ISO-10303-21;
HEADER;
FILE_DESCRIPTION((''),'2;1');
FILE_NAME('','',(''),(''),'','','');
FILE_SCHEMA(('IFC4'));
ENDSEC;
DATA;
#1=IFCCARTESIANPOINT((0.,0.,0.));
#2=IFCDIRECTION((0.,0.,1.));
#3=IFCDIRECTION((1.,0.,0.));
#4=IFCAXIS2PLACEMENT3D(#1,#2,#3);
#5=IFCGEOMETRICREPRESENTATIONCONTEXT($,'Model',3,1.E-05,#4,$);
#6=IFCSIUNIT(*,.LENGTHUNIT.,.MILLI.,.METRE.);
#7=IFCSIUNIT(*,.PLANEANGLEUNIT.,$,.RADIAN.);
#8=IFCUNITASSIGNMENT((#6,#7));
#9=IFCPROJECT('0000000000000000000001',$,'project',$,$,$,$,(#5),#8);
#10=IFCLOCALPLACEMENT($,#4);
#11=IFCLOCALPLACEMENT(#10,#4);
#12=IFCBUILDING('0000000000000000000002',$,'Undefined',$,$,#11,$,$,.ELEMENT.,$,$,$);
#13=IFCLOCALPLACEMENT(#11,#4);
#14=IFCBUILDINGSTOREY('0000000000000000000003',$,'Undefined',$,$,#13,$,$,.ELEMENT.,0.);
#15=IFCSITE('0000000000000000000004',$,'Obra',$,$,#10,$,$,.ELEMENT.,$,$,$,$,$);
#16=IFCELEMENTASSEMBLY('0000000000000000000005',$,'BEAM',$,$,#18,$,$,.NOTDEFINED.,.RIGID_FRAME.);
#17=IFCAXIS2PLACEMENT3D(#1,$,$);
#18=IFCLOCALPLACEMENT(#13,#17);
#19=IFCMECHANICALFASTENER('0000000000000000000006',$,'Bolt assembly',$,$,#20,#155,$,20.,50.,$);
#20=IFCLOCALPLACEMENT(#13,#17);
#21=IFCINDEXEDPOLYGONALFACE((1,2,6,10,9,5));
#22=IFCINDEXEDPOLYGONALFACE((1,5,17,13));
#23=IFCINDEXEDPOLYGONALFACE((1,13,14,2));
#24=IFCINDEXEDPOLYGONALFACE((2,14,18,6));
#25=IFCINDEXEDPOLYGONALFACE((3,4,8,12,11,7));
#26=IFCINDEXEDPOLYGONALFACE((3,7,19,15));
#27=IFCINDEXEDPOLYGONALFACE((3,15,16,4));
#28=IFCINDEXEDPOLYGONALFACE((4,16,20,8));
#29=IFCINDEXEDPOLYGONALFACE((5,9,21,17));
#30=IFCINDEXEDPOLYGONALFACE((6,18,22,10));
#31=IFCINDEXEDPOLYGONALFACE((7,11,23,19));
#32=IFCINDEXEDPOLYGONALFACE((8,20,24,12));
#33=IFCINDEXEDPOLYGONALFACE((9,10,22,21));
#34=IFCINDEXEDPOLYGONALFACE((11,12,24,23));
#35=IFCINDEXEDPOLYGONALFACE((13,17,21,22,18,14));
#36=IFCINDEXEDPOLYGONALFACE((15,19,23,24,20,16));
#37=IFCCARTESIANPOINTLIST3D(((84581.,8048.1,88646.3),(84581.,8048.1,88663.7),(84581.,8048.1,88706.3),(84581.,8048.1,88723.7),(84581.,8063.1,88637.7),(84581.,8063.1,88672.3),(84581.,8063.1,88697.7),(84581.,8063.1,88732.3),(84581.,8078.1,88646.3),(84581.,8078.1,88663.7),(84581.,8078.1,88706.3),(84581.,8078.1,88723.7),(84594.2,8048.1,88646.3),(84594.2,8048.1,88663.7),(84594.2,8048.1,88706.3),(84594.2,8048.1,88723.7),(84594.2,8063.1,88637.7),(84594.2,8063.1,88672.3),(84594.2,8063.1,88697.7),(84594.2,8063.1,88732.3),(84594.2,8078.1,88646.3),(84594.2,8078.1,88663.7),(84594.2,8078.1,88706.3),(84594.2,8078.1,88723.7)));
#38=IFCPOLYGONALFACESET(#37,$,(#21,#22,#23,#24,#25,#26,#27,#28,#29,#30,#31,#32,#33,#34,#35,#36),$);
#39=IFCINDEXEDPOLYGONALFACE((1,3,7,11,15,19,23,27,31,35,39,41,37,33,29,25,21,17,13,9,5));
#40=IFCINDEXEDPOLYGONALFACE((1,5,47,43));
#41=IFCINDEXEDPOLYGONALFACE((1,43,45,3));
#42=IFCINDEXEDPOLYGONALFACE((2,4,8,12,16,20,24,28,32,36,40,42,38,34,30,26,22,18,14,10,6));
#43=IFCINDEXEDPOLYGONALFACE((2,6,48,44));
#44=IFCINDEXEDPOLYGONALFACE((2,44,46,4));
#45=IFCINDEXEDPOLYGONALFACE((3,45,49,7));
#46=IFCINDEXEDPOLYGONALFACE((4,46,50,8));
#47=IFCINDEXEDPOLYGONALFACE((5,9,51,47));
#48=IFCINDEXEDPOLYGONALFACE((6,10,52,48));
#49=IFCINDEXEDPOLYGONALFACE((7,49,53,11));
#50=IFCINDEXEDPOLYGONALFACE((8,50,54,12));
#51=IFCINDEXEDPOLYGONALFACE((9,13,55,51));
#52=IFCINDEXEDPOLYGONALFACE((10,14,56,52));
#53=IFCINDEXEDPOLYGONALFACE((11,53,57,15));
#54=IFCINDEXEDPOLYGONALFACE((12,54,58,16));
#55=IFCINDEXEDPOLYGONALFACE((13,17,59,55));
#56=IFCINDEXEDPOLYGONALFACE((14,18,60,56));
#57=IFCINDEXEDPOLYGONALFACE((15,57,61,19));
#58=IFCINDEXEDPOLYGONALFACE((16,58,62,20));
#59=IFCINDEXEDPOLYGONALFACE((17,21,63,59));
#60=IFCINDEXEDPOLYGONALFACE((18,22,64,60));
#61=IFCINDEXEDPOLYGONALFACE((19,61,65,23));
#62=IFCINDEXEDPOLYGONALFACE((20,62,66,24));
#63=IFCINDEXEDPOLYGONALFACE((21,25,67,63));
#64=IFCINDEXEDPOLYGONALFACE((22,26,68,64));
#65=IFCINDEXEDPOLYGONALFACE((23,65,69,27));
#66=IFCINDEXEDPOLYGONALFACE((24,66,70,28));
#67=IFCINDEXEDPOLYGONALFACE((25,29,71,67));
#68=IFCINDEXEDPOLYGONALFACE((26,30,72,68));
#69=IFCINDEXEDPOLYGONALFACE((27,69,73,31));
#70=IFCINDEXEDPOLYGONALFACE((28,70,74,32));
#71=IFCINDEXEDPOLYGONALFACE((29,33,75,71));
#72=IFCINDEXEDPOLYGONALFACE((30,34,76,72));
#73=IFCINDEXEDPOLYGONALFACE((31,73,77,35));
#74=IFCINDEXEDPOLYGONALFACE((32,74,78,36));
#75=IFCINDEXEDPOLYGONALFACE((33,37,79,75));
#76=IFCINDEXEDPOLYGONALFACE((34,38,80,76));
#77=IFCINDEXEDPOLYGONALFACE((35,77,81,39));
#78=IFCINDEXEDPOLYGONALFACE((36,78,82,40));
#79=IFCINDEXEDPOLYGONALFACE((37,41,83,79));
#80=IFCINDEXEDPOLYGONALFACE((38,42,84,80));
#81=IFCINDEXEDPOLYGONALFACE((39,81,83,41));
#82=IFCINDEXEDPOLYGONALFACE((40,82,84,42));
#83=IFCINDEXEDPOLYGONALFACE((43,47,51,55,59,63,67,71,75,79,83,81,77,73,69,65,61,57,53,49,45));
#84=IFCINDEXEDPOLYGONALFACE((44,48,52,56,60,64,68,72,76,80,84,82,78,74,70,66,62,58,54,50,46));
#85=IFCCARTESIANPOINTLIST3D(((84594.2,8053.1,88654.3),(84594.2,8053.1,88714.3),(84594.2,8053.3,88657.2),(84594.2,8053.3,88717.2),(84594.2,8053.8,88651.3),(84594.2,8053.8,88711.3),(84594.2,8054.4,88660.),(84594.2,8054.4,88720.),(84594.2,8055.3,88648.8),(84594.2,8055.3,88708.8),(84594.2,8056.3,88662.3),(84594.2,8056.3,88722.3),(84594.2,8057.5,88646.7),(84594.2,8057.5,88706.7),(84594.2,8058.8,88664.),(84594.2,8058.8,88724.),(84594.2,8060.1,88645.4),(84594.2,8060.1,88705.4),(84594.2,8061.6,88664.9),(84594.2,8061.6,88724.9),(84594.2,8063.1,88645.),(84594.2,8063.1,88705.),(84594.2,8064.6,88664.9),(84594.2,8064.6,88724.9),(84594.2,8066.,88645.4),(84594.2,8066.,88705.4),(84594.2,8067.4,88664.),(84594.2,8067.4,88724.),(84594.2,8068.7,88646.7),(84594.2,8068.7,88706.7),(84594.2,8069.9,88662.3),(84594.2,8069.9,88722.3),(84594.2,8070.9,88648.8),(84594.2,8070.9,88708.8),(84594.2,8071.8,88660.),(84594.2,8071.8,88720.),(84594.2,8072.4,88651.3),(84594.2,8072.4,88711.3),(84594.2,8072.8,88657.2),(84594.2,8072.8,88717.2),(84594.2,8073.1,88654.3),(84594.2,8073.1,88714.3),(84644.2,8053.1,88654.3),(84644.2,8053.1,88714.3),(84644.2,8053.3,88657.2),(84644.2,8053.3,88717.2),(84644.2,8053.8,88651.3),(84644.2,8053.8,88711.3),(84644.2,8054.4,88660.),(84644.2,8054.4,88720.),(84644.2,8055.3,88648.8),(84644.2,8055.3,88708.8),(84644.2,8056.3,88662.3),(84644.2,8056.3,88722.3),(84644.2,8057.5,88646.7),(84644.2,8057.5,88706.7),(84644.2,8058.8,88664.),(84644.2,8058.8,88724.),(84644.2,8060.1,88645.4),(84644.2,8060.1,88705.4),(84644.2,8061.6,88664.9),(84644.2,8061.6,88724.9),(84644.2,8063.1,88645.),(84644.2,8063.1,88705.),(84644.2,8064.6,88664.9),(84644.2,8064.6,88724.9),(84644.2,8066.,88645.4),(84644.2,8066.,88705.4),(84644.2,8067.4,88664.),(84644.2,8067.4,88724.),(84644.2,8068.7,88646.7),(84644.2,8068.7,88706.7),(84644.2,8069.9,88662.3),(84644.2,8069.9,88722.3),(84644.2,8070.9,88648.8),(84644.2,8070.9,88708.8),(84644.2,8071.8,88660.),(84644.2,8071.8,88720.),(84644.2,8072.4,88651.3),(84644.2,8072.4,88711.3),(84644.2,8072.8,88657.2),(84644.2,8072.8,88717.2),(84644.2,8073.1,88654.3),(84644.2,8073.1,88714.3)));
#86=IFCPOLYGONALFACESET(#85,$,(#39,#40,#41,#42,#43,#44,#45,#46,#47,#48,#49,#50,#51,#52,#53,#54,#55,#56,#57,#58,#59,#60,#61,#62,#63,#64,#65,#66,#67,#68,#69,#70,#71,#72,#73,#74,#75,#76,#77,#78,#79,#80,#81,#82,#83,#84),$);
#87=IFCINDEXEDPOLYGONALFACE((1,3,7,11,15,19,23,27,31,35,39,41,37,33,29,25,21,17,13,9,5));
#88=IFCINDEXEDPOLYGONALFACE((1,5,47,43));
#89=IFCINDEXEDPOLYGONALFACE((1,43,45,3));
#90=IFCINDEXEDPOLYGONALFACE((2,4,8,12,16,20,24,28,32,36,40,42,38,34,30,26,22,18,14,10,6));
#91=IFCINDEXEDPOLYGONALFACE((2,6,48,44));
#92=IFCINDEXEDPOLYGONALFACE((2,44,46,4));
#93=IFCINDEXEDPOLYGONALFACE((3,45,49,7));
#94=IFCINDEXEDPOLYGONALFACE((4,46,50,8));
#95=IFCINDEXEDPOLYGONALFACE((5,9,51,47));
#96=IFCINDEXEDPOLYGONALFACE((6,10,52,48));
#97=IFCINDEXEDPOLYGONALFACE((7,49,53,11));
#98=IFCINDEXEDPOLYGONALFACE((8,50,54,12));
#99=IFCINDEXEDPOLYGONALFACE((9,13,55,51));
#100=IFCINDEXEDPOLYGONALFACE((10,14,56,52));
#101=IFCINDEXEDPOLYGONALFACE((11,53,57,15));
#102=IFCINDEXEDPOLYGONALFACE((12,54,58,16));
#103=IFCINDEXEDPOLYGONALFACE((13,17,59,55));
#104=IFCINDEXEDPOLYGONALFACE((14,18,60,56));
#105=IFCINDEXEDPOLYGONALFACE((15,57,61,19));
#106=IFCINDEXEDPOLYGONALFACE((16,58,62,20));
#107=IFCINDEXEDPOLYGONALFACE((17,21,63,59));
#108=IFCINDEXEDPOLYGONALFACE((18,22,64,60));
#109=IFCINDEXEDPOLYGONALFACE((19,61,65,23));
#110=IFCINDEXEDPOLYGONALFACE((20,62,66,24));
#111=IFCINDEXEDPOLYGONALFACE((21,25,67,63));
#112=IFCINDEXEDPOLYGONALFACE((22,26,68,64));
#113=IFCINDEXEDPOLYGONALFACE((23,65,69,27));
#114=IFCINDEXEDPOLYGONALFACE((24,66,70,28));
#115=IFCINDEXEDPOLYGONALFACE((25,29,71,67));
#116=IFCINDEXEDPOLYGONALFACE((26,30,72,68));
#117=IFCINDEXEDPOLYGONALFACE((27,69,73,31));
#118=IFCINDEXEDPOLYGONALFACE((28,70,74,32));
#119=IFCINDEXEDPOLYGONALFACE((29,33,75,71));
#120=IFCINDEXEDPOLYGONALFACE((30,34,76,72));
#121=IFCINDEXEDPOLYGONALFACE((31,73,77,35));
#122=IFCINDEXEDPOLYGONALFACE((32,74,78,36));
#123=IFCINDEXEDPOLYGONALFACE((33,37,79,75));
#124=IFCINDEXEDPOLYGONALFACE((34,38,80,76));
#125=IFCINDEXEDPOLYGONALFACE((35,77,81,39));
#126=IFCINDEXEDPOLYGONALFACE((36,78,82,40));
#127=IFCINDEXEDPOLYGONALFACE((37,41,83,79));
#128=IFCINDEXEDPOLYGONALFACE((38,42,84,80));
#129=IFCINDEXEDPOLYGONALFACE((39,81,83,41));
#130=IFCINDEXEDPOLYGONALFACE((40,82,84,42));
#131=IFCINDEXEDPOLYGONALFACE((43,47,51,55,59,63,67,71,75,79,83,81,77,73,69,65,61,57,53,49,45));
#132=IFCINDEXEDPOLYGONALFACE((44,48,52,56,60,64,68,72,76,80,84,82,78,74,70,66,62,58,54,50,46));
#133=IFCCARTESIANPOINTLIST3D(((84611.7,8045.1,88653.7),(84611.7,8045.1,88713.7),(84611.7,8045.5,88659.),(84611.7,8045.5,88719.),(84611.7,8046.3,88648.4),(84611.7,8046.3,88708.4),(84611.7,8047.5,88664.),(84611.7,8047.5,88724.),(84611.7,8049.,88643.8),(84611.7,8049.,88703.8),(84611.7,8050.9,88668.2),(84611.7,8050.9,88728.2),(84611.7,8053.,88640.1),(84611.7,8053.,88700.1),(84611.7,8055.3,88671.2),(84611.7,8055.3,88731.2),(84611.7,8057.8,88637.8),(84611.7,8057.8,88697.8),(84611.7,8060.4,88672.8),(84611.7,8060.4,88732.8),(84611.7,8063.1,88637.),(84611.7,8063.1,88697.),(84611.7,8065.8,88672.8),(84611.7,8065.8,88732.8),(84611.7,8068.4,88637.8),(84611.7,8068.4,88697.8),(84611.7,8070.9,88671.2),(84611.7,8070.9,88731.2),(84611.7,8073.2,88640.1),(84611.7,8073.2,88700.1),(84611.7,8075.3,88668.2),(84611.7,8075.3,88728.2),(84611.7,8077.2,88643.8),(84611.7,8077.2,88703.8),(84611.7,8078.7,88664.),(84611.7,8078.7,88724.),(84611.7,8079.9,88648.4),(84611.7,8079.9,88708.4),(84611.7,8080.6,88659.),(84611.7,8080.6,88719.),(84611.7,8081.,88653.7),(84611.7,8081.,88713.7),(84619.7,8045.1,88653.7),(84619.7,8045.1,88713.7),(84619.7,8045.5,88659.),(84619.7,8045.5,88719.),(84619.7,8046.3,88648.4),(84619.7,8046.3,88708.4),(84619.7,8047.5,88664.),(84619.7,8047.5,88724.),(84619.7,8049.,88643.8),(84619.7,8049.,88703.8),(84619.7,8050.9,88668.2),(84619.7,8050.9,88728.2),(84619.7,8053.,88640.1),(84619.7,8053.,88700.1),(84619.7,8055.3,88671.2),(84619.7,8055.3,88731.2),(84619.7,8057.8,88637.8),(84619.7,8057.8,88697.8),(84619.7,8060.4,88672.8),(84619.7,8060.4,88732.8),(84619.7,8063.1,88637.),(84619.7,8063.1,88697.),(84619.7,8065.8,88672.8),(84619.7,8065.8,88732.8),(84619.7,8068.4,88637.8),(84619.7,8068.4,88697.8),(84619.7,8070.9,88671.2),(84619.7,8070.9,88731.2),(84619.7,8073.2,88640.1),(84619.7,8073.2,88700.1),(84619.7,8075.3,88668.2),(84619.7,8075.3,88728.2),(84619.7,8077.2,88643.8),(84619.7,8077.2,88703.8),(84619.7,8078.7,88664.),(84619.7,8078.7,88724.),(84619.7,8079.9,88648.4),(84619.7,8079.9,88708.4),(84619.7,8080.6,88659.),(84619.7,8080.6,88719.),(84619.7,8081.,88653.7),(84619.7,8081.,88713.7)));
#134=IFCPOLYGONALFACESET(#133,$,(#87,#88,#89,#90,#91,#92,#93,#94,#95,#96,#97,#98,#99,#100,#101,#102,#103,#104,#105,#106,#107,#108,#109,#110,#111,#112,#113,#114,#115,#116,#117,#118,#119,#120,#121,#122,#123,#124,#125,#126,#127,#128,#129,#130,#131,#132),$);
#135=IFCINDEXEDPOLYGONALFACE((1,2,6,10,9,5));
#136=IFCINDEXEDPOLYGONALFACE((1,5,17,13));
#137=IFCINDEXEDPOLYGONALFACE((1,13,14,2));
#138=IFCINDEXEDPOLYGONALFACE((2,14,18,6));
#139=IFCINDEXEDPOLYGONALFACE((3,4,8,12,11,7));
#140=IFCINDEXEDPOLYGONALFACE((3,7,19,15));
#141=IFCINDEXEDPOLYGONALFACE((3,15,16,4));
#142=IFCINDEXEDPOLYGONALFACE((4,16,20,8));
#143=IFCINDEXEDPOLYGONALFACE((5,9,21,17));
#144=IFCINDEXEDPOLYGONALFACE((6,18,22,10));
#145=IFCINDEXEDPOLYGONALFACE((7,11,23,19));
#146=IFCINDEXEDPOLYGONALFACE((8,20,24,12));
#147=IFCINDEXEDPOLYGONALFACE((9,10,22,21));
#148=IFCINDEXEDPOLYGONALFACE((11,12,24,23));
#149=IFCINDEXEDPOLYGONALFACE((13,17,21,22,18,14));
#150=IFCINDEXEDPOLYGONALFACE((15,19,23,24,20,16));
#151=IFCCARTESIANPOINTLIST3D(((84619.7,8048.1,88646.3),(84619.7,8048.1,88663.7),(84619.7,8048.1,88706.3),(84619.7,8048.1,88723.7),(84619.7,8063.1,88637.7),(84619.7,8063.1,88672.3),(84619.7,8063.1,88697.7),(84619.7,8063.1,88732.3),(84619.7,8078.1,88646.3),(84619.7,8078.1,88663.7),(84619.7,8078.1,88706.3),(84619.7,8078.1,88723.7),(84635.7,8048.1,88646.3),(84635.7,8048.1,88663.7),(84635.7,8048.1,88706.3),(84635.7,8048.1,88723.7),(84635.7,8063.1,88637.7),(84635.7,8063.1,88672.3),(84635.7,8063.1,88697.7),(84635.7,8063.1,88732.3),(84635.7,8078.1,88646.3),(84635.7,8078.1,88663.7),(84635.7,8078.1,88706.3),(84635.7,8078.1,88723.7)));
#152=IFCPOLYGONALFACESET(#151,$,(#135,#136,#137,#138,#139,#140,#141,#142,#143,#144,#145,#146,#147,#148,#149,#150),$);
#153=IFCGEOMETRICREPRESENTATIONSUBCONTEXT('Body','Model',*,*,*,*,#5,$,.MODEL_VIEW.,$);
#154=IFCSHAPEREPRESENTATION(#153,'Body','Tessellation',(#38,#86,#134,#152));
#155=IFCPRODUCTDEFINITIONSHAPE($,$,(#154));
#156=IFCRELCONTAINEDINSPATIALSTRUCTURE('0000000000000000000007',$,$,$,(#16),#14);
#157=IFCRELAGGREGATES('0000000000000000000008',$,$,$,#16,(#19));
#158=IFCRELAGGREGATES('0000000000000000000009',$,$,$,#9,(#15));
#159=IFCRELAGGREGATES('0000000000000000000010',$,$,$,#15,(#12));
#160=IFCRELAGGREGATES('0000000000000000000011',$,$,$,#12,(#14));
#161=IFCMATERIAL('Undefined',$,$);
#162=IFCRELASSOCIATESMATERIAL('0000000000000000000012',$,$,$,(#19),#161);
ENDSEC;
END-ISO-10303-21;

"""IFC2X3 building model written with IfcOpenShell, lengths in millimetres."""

from ifc_helpers import new_model, si_unit, frame, origin_with_axes, origin_2d_with_axis, place, context, subcontext, project, spatial, polyline, circle, outline, extrude, source, transform, mapped, material, element, aggregate, save


model = new_model("IFC2X3")

# Units and contexts
model_context = context("Model", 3, precision=1e-05, world=origin_with_axes())
body_context = subcontext(model_context, "Body", "Model", "MODEL_VIEW")
ifc_project = project(units=[si_unit("LENGTHUNIT", "METRE", prefix="MILLI"), si_unit("PLANEANGLEUNIT", "RADIAN")], contexts=[model_context])

# Site, building, storey
site_placement = place(None, origin_with_axes())
site = spatial("IfcSite", under=ifc_project, at=site_placement, Name="Obra", CompositionType="ELEMENT")
building_placement = place(site_placement, origin_with_axes())
building = spatial("IfcBuilding", under=site, at=building_placement, Name="Undefined", CompositionType="ELEMENT")
storey_placement = place(building_placement, origin_with_axes())
storey = spatial("IfcBuildingStorey", under=building, at=storey_placement, Name="Undefined", CompositionType="ELEMENT", Elevation=0.0)

# Shared definitions
ifc_material_1 = material(Name="Undefined")

# Element assembly, mechanical fastener
shared_shape_1 = source(origin_with_axes(), body_context, "Body", "SweptSolid", [
    extrude(outline(polyline([(17.3, 0.0), (8.7, 15.0), (-8.7, 15.0), (-17.3, 0.0), (-8.7, -15.0), (8.7, -15.0), (17.3, 0.0)])), frame((0.0, -27.0, 0.0), z_axis=(0.0, 1.0, 0.0), x_axis=(1.0, 0.0, 0.0)), (0.0, 0.0, 1.0), 13.2),
    extrude(circle(Radius=10.0, at=origin_2d_with_axis()), frame((0.0, -13.8, 0.0), z_axis=(0.0, 1.0, 0.0), x_axis=(1.0, 0.0, 0.0)), (0.0, 0.0, 1.0), 50.0),
    extrude(circle(Radius=18.0, at=origin_2d_with_axis()), frame((0.0, 3.7, 0.0), z_axis=(0.0, 1.0, 0.0), x_axis=(1.0, 0.0, 0.0)), (0.0, 0.0, 1.0), 8.0),
    extrude(outline(polyline([(17.3, 0.0), (8.7, 15.0), (-8.7, 15.0), (-17.3, 0.0), (-8.7, -15.0), (8.7, -15.0), (17.3, 0.0)])), frame((0.0, 11.7, 0.0), z_axis=(0.0, 1.0, 0.0), x_axis=(1.0, 0.0, 0.0)), (0.0, 0.0, 1.0), 16.0),
])
assembly_1_placement = place(storey_placement, origin_with_axes())
assembly_1 = element("IfcElementAssembly", 1, at=assembly_1_placement, inside=storey, Name="BEAM", AssemblyPlace="NOTDEFINED", PredefinedType="RIGID_FRAME")
mechanical_fastener_1_placement = place(assembly_1_placement, frame((84607.9, 8103.1, 88850.0), z_axis=(0.0, -1.0, 0.0), x_axis=(0.0, 0.0, -1.0)))
mechanical_fastener_1 = element("IfcMechanicalFastener", 2, at=mechanical_fastener_1_placement, material=ifc_material_1, Name="Bolt assembly", NominalDiameter=20.0, NominalLength=50.0, context=body_context, shape_type="MappedRepresentation", body=[
    mapped(shared_shape_1, transform((135.0, 0.0, 40.0))),
    mapped(shared_shape_1, transform((195.0, 0.0, 40.0))),
])
aggregate(assembly_1, [mechanical_fastener_1])

save(model, "model.ifc")
